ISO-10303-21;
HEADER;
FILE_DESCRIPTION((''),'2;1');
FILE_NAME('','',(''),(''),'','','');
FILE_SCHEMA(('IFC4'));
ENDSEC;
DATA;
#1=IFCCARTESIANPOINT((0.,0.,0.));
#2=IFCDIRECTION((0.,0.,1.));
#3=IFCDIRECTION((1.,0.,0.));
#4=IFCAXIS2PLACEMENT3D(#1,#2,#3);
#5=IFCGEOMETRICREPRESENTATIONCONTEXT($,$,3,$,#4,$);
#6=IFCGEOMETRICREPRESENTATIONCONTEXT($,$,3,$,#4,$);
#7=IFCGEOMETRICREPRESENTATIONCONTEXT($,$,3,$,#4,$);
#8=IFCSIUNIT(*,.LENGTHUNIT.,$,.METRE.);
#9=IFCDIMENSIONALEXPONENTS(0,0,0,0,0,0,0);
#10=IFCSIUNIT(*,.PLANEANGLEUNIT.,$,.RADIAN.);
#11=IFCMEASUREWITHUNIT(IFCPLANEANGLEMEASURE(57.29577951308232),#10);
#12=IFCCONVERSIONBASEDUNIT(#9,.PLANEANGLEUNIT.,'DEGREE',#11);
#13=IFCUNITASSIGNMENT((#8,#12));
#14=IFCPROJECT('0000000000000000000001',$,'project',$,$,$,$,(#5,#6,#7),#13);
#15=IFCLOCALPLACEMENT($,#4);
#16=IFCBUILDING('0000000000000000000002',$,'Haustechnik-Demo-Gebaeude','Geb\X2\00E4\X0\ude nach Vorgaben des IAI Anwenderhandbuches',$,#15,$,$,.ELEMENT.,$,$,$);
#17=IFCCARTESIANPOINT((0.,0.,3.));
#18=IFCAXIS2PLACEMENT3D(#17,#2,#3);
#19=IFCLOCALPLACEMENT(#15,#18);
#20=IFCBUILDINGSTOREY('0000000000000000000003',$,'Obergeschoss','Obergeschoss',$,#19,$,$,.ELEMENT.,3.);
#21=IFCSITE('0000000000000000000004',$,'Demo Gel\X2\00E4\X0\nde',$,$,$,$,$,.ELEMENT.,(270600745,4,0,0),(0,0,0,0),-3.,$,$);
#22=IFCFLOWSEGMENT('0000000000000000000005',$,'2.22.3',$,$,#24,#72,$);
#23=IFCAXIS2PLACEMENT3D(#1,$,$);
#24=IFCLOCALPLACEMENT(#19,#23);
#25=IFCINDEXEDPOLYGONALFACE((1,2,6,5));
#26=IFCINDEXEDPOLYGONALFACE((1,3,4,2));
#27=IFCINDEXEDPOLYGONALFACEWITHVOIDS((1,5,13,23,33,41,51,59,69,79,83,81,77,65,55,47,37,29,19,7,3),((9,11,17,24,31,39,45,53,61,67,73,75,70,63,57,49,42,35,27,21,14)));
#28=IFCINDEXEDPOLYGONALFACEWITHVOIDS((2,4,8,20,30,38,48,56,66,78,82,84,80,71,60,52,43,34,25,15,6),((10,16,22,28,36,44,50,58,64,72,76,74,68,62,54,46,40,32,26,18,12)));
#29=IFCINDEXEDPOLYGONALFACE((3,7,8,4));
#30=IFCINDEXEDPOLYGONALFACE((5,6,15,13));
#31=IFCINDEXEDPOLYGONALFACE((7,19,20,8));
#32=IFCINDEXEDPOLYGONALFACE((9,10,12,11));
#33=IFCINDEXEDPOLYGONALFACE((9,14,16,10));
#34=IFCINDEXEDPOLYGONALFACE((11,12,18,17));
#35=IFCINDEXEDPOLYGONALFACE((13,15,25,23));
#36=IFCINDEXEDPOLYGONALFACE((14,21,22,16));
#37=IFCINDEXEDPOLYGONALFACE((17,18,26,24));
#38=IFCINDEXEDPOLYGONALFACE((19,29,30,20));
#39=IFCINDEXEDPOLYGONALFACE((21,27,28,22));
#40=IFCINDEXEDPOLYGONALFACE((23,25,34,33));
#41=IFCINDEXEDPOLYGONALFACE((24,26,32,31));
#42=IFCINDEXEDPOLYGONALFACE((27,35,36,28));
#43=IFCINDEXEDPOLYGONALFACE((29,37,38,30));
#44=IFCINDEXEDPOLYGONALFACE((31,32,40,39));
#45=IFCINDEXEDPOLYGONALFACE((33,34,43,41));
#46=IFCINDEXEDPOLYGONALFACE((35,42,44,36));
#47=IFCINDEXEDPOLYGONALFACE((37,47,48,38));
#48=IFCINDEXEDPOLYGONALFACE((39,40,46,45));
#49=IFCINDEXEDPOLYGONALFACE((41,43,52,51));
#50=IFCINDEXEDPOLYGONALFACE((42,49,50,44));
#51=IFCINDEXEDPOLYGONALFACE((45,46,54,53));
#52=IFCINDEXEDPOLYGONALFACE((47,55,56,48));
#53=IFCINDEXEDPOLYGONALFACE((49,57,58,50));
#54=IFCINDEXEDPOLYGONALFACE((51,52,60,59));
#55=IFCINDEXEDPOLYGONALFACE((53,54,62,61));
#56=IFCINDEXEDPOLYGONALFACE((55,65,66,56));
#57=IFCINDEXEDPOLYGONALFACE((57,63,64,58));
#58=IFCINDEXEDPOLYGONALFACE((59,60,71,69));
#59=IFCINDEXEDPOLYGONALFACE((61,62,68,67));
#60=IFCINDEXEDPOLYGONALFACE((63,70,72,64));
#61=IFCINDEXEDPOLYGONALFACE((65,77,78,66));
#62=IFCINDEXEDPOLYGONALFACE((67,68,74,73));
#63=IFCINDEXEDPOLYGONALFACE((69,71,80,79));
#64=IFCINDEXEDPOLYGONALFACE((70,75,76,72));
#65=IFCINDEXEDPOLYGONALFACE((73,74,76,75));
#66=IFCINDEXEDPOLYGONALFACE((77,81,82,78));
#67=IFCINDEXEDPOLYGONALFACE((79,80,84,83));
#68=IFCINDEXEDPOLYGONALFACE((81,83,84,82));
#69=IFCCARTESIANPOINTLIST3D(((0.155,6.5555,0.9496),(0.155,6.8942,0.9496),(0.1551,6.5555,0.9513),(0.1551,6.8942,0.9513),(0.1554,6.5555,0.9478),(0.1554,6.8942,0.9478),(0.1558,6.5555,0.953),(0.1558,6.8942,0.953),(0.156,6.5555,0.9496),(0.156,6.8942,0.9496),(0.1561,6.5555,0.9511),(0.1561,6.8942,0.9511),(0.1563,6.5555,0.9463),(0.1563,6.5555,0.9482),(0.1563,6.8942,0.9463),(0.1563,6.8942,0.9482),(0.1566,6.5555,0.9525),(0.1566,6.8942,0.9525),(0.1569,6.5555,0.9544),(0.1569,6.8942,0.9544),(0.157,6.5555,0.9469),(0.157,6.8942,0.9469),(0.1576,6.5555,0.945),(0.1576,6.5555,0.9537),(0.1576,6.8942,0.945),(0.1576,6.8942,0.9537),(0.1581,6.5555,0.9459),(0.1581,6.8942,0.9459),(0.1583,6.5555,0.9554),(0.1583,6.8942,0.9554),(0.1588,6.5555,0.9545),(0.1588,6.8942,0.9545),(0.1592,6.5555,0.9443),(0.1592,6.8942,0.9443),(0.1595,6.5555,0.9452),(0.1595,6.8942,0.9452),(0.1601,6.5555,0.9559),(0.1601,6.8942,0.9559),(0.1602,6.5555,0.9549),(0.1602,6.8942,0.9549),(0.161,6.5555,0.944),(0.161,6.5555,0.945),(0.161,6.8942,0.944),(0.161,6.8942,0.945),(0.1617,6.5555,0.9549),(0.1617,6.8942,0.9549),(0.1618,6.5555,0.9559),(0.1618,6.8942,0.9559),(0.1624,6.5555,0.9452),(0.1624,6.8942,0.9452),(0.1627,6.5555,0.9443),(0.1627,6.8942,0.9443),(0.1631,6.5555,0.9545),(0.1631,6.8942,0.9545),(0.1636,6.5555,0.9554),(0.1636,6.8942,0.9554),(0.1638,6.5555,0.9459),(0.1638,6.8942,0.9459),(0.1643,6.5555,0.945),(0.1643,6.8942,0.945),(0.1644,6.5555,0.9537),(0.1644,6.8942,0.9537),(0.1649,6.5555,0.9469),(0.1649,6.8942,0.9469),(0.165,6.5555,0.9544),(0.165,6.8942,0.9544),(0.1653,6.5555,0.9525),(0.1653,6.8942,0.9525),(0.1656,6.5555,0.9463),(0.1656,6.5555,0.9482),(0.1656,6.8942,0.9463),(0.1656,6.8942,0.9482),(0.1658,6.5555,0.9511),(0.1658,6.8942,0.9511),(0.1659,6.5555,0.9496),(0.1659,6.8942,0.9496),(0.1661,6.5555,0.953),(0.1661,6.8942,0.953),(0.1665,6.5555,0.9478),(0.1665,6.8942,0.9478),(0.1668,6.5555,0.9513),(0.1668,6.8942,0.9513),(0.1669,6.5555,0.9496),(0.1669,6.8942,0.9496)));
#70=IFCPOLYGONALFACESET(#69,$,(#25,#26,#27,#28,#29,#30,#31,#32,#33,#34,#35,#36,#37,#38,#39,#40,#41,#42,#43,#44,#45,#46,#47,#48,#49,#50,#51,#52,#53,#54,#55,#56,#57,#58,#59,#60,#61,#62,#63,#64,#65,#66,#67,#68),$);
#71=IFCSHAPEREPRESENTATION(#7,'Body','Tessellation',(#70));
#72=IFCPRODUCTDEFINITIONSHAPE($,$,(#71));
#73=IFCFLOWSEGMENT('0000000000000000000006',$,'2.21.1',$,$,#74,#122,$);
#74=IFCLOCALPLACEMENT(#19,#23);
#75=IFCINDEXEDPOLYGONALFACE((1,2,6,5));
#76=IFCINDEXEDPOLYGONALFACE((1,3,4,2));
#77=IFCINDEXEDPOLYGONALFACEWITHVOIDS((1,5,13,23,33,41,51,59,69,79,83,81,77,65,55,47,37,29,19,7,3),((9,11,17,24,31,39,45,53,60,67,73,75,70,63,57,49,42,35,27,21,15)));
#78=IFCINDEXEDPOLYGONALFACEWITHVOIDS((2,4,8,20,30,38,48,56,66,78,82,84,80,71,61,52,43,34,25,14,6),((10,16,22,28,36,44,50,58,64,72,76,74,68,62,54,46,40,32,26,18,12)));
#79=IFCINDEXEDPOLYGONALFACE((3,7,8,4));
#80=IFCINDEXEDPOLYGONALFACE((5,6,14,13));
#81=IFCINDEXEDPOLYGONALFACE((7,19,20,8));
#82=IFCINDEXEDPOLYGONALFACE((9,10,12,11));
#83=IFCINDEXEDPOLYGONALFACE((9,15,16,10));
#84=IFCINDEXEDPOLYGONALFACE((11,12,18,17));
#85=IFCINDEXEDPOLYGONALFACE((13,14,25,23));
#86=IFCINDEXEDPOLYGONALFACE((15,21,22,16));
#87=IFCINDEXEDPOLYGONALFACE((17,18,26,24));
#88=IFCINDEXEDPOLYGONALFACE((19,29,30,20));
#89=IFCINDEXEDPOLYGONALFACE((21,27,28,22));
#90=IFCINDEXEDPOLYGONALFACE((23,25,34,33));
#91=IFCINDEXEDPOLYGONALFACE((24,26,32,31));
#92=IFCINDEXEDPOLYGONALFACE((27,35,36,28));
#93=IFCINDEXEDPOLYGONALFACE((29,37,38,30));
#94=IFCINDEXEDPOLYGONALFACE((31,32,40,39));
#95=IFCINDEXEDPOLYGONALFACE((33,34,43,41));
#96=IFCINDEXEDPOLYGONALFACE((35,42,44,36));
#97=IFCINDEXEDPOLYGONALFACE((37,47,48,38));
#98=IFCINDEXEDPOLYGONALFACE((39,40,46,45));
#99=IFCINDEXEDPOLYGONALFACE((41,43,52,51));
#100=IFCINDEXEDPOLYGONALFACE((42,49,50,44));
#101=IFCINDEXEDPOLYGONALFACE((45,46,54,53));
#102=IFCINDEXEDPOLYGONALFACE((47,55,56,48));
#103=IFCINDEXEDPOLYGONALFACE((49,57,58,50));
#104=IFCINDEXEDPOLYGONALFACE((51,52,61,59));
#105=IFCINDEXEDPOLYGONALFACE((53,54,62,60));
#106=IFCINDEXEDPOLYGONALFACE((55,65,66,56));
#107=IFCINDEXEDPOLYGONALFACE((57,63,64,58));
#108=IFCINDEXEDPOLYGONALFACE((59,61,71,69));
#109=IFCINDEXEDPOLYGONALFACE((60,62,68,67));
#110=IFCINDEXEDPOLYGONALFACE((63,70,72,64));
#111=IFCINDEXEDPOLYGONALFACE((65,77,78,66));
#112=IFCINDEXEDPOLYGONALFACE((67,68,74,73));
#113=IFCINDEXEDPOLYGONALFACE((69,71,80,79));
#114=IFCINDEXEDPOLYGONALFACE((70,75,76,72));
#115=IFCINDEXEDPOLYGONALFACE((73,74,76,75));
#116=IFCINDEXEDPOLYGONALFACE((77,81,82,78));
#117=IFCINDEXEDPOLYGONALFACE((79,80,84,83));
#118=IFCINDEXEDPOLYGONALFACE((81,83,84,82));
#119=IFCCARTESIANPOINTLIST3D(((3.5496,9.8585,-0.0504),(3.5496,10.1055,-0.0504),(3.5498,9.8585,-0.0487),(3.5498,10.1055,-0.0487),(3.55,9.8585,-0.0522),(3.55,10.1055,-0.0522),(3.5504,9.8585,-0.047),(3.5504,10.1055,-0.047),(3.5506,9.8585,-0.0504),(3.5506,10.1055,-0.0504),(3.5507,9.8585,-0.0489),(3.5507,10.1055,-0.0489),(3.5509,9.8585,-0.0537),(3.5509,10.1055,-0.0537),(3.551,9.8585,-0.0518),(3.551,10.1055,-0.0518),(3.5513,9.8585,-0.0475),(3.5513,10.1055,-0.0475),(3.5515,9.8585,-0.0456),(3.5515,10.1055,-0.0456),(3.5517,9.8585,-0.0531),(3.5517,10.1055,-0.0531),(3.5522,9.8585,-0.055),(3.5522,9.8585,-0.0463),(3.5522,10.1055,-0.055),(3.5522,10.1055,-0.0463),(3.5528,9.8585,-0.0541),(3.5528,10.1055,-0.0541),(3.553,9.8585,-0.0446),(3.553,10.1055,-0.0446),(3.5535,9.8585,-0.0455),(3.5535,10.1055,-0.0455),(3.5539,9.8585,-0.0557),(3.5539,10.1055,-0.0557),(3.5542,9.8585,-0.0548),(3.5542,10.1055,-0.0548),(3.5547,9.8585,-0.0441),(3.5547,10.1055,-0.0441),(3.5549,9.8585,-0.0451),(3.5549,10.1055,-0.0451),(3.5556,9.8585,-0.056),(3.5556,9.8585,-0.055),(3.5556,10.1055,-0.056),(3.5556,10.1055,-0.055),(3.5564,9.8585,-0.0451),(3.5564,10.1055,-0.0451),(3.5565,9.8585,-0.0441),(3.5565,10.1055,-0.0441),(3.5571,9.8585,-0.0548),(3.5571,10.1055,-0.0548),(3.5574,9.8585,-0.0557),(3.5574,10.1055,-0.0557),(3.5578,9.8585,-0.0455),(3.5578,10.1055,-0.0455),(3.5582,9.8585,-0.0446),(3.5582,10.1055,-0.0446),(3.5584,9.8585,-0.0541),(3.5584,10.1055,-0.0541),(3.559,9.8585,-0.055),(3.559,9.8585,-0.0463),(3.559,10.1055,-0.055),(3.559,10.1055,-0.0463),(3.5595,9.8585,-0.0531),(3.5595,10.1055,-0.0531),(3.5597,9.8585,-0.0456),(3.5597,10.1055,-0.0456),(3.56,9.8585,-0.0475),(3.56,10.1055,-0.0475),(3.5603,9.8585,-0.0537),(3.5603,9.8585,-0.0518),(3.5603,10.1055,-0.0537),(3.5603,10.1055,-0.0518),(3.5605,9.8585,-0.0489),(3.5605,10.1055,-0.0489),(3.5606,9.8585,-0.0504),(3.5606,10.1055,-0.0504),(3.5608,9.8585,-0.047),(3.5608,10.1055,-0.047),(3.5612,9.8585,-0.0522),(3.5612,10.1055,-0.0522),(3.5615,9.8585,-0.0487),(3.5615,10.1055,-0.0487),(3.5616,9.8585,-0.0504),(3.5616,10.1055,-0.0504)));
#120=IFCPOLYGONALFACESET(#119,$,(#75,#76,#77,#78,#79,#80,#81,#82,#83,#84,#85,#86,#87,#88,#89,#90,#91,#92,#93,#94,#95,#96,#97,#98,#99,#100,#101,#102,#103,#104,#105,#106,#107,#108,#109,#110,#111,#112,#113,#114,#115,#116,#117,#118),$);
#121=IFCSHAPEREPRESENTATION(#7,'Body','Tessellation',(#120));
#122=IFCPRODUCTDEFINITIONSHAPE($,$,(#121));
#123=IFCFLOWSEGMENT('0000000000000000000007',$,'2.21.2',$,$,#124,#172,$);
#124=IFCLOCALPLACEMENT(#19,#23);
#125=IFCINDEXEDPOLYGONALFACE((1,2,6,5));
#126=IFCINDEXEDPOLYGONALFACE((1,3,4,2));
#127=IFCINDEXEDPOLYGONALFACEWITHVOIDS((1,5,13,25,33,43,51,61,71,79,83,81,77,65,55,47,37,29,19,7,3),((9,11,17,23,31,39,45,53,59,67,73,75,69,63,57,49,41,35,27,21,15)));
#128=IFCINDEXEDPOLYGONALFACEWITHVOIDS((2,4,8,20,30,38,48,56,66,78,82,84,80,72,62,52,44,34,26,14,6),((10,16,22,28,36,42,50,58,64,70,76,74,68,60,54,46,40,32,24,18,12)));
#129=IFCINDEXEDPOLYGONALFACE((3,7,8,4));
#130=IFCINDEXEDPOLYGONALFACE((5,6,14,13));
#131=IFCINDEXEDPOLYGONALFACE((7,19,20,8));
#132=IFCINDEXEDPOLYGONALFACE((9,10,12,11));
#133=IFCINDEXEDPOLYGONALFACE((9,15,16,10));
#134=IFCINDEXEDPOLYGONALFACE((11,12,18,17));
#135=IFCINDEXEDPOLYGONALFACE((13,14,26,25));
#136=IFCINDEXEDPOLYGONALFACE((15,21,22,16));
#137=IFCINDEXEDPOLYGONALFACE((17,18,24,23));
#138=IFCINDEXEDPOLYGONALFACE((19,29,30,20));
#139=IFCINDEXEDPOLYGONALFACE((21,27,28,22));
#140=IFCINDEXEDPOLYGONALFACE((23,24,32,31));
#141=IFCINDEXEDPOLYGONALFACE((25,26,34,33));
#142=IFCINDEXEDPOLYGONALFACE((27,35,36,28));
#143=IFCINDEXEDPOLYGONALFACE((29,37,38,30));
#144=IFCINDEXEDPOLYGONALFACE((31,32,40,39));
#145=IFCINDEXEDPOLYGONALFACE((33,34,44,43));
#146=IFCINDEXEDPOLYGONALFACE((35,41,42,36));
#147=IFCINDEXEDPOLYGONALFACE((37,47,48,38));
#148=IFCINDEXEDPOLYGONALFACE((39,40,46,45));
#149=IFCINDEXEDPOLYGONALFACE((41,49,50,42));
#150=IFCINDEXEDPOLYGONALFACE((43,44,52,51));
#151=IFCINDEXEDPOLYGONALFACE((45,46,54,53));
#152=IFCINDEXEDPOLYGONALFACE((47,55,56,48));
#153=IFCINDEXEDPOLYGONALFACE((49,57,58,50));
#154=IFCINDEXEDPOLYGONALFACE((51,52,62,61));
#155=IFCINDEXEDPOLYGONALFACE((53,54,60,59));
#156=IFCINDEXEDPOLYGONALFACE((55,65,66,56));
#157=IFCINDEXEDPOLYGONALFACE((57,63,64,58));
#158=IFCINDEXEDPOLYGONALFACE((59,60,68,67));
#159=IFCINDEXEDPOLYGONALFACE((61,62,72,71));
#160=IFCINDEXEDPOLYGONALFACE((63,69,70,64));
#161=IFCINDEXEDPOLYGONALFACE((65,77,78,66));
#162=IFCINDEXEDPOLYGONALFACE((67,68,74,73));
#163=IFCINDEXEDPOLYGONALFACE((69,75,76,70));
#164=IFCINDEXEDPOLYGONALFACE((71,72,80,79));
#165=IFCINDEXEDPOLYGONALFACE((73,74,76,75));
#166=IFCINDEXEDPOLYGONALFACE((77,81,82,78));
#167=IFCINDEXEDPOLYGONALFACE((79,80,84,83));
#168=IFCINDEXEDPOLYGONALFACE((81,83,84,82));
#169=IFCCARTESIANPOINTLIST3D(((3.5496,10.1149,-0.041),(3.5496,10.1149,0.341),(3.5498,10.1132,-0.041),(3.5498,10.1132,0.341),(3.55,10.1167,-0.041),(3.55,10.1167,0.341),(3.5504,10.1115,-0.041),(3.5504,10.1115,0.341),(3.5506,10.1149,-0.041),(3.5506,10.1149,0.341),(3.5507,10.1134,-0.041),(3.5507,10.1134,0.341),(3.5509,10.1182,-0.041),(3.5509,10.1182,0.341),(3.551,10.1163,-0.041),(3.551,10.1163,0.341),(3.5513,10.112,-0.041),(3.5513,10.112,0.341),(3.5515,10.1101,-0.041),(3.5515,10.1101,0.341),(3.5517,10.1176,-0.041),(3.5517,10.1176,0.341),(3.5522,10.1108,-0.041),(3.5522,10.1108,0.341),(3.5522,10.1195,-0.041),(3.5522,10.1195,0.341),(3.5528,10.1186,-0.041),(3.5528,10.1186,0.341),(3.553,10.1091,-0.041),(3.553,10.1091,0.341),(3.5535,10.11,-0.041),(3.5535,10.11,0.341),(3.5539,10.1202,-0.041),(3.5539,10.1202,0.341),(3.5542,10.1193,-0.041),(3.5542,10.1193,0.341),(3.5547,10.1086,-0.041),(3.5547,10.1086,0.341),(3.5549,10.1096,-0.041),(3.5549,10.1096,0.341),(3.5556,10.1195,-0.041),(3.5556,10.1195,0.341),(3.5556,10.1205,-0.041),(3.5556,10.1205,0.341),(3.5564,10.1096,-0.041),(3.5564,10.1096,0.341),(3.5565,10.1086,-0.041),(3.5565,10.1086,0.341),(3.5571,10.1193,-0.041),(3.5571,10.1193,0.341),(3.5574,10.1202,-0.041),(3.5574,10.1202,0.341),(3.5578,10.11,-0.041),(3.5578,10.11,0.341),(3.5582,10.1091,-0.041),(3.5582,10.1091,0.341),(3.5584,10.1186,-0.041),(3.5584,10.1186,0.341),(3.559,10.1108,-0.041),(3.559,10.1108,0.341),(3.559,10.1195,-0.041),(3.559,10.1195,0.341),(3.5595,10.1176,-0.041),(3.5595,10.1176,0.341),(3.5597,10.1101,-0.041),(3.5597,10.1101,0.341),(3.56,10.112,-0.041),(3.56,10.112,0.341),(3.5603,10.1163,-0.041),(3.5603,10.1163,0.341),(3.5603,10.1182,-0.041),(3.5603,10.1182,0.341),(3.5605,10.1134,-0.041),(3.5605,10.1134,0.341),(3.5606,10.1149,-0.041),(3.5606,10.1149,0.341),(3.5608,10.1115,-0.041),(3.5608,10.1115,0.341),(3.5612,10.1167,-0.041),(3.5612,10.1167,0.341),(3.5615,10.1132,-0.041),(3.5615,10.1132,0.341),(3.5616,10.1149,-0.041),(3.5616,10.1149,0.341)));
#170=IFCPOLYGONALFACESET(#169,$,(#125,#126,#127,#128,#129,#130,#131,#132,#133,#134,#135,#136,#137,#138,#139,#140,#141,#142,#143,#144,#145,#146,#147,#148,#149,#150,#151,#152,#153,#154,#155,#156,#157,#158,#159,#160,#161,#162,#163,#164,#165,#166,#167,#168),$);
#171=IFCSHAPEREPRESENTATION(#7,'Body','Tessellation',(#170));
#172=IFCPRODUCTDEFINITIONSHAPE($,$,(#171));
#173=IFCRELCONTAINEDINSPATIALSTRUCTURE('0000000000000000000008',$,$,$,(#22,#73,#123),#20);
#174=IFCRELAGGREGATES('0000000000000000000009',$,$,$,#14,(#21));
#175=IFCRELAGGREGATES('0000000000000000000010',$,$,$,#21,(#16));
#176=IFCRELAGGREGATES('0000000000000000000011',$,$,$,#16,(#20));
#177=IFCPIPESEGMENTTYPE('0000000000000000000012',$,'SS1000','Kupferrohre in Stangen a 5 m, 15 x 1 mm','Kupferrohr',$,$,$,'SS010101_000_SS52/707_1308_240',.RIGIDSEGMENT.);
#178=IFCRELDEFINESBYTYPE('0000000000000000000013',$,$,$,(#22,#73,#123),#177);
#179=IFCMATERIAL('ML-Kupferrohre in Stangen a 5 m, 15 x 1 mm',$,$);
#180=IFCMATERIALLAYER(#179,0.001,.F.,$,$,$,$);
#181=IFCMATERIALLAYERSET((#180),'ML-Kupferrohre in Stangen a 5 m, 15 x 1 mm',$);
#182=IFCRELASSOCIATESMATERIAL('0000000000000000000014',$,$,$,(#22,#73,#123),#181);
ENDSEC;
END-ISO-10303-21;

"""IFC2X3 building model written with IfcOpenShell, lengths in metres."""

from ifc_helpers import new_model, entity, si_unit, converted_unit, frame, origin_with_axes, origin_2d_with_axis, place, context, project, spatial, hollow_circle, extrude, material, layer, layer_set, layer_usage, type_object, element, save


model = new_model("IFC2X3")

# Units and contexts
context_of_model_1 = context(None, 3, world=origin_with_axes())
context_of_model_2 = context(None, 3, world=origin_with_axes())
context_of_model_3 = context(None, 3, world=origin_with_axes())
ifc_project = project(units=[si_unit("LENGTHUNIT", "METRE"), converted_unit("PLANEANGLEUNIT", "DEGREE", entity("IfcPlaneAngleMeasure", 57.29577951308232), si_unit("PLANEANGLEUNIT", "RADIAN"), dimensions=[0, 0, 0, 0, 0, 0, 0])], contexts=[context_of_model_1, context_of_model_2, context_of_model_3])

# Site, building, storey
site = spatial("IfcSite", under=ifc_project, Name="Demo Gelände", CompositionType="ELEMENT", RefLatitude=(270600745, 4, 0, 0), RefLongitude=(0, 0, 0, 0), RefElevation=-3.0)
building_placement = place(None, origin_with_axes())
building = spatial("IfcBuilding", under=site, at=building_placement, Name="Haustechnik-Demo-Gebaeude", Description="Gebäude nach Vorgaben des IAI Anwenderhandbuches", CompositionType="ELEMENT")
storey_placement = place(building_placement, frame((0.0, 0.0, 3.0), z_axis=(0.0, 0.0, 1.0), x_axis=(1.0, 0.0, 0.0)))
storey = spatial("IfcBuildingStorey", under=building, at=storey_placement, Name="Obergeschoss", Description="Obergeschoss", CompositionType="ELEMENT", Elevation=3.0)

# Flow segments
ifc_material = material(Name="ML-Kupferrohre in Stangen a 5 m, 15 x 1 mm")
ifc_layer = layer(ifc_material, 0.001, ventilated=False)
ifc_layer_set = layer_set([ifc_layer], Name="ML-Kupferrohre in Stangen a 5 m, 15 x 1 mm")
ifc_layer_usage = layer_usage(ifc_layer_set, "AXIS2", "POSITIVE", 0.0)
pipe_segment_type_1 = type_object("IfcPipeSegmentType", Name="SS1000", Description="Kupferrohre in Stangen a 5 m, 15 x 1 mm", ApplicableOccurrence="Kupferrohr", ElementType="SS010101_000_SS52/707_1308_240", PredefinedType="RIGIDSEGMENT")
flow_segment_1_placement = place(storey_placement, frame((0.161, 6.8942, 0.95), z_axis=(0.0, -1.0, 0.0), x_axis=(0.0, 0.0, -1.0)))
element("IfcFlowSegment", 1, at=flow_segment_1_placement, inside=storey, type_object=pipe_segment_type_1, material=ifc_layer_usage, Name="2.22.3", context=context_of_model_3, shape_type="SweptSolid", body=[
    extrude(hollow_circle(Radius=0.006, WallThickness=0.001, at=origin_2d_with_axis()), origin_with_axes(), (0.0, 0.0, 1.0), 0.3387),
])
flow_segment_2_placement = place(storey_placement, frame((3.5556, 9.8585, -0.05), z_axis=(0.0, 1.0, 0.0), x_axis=(0.0, 0.0, -1.0)))
element("IfcFlowSegment", 2, at=flow_segment_2_placement, inside=storey, type_object=pipe_segment_type_1, material=ifc_layer_usage, Name="2.21.1", context=context_of_model_3, shape_type="SweptSolid", body=[
    extrude(hollow_circle(Radius=0.006, WallThickness=0.001, at=origin_2d_with_axis()), origin_with_axes(), (0.0, 0.0, 1.0), 0.247),
])
flow_segment_3_placement = place(storey_placement, frame((3.5556, 10.1145, -0.041), z_axis=(0.0, 0.0, 1.0), x_axis=(0.0, 1.0, 0.0)))
element("IfcFlowSegment", 3, at=flow_segment_3_placement, inside=storey, type_object=pipe_segment_type_1, material=ifc_layer_usage, Name="2.21.2", context=context_of_model_3, shape_type="SweptSolid", body=[
    extrude(hollow_circle(Radius=0.006, WallThickness=0.001, at=origin_2d_with_axis()), origin_with_axes(), (0.0, 0.0, 1.0), 0.382),
])

save(model, "model.ifc")
